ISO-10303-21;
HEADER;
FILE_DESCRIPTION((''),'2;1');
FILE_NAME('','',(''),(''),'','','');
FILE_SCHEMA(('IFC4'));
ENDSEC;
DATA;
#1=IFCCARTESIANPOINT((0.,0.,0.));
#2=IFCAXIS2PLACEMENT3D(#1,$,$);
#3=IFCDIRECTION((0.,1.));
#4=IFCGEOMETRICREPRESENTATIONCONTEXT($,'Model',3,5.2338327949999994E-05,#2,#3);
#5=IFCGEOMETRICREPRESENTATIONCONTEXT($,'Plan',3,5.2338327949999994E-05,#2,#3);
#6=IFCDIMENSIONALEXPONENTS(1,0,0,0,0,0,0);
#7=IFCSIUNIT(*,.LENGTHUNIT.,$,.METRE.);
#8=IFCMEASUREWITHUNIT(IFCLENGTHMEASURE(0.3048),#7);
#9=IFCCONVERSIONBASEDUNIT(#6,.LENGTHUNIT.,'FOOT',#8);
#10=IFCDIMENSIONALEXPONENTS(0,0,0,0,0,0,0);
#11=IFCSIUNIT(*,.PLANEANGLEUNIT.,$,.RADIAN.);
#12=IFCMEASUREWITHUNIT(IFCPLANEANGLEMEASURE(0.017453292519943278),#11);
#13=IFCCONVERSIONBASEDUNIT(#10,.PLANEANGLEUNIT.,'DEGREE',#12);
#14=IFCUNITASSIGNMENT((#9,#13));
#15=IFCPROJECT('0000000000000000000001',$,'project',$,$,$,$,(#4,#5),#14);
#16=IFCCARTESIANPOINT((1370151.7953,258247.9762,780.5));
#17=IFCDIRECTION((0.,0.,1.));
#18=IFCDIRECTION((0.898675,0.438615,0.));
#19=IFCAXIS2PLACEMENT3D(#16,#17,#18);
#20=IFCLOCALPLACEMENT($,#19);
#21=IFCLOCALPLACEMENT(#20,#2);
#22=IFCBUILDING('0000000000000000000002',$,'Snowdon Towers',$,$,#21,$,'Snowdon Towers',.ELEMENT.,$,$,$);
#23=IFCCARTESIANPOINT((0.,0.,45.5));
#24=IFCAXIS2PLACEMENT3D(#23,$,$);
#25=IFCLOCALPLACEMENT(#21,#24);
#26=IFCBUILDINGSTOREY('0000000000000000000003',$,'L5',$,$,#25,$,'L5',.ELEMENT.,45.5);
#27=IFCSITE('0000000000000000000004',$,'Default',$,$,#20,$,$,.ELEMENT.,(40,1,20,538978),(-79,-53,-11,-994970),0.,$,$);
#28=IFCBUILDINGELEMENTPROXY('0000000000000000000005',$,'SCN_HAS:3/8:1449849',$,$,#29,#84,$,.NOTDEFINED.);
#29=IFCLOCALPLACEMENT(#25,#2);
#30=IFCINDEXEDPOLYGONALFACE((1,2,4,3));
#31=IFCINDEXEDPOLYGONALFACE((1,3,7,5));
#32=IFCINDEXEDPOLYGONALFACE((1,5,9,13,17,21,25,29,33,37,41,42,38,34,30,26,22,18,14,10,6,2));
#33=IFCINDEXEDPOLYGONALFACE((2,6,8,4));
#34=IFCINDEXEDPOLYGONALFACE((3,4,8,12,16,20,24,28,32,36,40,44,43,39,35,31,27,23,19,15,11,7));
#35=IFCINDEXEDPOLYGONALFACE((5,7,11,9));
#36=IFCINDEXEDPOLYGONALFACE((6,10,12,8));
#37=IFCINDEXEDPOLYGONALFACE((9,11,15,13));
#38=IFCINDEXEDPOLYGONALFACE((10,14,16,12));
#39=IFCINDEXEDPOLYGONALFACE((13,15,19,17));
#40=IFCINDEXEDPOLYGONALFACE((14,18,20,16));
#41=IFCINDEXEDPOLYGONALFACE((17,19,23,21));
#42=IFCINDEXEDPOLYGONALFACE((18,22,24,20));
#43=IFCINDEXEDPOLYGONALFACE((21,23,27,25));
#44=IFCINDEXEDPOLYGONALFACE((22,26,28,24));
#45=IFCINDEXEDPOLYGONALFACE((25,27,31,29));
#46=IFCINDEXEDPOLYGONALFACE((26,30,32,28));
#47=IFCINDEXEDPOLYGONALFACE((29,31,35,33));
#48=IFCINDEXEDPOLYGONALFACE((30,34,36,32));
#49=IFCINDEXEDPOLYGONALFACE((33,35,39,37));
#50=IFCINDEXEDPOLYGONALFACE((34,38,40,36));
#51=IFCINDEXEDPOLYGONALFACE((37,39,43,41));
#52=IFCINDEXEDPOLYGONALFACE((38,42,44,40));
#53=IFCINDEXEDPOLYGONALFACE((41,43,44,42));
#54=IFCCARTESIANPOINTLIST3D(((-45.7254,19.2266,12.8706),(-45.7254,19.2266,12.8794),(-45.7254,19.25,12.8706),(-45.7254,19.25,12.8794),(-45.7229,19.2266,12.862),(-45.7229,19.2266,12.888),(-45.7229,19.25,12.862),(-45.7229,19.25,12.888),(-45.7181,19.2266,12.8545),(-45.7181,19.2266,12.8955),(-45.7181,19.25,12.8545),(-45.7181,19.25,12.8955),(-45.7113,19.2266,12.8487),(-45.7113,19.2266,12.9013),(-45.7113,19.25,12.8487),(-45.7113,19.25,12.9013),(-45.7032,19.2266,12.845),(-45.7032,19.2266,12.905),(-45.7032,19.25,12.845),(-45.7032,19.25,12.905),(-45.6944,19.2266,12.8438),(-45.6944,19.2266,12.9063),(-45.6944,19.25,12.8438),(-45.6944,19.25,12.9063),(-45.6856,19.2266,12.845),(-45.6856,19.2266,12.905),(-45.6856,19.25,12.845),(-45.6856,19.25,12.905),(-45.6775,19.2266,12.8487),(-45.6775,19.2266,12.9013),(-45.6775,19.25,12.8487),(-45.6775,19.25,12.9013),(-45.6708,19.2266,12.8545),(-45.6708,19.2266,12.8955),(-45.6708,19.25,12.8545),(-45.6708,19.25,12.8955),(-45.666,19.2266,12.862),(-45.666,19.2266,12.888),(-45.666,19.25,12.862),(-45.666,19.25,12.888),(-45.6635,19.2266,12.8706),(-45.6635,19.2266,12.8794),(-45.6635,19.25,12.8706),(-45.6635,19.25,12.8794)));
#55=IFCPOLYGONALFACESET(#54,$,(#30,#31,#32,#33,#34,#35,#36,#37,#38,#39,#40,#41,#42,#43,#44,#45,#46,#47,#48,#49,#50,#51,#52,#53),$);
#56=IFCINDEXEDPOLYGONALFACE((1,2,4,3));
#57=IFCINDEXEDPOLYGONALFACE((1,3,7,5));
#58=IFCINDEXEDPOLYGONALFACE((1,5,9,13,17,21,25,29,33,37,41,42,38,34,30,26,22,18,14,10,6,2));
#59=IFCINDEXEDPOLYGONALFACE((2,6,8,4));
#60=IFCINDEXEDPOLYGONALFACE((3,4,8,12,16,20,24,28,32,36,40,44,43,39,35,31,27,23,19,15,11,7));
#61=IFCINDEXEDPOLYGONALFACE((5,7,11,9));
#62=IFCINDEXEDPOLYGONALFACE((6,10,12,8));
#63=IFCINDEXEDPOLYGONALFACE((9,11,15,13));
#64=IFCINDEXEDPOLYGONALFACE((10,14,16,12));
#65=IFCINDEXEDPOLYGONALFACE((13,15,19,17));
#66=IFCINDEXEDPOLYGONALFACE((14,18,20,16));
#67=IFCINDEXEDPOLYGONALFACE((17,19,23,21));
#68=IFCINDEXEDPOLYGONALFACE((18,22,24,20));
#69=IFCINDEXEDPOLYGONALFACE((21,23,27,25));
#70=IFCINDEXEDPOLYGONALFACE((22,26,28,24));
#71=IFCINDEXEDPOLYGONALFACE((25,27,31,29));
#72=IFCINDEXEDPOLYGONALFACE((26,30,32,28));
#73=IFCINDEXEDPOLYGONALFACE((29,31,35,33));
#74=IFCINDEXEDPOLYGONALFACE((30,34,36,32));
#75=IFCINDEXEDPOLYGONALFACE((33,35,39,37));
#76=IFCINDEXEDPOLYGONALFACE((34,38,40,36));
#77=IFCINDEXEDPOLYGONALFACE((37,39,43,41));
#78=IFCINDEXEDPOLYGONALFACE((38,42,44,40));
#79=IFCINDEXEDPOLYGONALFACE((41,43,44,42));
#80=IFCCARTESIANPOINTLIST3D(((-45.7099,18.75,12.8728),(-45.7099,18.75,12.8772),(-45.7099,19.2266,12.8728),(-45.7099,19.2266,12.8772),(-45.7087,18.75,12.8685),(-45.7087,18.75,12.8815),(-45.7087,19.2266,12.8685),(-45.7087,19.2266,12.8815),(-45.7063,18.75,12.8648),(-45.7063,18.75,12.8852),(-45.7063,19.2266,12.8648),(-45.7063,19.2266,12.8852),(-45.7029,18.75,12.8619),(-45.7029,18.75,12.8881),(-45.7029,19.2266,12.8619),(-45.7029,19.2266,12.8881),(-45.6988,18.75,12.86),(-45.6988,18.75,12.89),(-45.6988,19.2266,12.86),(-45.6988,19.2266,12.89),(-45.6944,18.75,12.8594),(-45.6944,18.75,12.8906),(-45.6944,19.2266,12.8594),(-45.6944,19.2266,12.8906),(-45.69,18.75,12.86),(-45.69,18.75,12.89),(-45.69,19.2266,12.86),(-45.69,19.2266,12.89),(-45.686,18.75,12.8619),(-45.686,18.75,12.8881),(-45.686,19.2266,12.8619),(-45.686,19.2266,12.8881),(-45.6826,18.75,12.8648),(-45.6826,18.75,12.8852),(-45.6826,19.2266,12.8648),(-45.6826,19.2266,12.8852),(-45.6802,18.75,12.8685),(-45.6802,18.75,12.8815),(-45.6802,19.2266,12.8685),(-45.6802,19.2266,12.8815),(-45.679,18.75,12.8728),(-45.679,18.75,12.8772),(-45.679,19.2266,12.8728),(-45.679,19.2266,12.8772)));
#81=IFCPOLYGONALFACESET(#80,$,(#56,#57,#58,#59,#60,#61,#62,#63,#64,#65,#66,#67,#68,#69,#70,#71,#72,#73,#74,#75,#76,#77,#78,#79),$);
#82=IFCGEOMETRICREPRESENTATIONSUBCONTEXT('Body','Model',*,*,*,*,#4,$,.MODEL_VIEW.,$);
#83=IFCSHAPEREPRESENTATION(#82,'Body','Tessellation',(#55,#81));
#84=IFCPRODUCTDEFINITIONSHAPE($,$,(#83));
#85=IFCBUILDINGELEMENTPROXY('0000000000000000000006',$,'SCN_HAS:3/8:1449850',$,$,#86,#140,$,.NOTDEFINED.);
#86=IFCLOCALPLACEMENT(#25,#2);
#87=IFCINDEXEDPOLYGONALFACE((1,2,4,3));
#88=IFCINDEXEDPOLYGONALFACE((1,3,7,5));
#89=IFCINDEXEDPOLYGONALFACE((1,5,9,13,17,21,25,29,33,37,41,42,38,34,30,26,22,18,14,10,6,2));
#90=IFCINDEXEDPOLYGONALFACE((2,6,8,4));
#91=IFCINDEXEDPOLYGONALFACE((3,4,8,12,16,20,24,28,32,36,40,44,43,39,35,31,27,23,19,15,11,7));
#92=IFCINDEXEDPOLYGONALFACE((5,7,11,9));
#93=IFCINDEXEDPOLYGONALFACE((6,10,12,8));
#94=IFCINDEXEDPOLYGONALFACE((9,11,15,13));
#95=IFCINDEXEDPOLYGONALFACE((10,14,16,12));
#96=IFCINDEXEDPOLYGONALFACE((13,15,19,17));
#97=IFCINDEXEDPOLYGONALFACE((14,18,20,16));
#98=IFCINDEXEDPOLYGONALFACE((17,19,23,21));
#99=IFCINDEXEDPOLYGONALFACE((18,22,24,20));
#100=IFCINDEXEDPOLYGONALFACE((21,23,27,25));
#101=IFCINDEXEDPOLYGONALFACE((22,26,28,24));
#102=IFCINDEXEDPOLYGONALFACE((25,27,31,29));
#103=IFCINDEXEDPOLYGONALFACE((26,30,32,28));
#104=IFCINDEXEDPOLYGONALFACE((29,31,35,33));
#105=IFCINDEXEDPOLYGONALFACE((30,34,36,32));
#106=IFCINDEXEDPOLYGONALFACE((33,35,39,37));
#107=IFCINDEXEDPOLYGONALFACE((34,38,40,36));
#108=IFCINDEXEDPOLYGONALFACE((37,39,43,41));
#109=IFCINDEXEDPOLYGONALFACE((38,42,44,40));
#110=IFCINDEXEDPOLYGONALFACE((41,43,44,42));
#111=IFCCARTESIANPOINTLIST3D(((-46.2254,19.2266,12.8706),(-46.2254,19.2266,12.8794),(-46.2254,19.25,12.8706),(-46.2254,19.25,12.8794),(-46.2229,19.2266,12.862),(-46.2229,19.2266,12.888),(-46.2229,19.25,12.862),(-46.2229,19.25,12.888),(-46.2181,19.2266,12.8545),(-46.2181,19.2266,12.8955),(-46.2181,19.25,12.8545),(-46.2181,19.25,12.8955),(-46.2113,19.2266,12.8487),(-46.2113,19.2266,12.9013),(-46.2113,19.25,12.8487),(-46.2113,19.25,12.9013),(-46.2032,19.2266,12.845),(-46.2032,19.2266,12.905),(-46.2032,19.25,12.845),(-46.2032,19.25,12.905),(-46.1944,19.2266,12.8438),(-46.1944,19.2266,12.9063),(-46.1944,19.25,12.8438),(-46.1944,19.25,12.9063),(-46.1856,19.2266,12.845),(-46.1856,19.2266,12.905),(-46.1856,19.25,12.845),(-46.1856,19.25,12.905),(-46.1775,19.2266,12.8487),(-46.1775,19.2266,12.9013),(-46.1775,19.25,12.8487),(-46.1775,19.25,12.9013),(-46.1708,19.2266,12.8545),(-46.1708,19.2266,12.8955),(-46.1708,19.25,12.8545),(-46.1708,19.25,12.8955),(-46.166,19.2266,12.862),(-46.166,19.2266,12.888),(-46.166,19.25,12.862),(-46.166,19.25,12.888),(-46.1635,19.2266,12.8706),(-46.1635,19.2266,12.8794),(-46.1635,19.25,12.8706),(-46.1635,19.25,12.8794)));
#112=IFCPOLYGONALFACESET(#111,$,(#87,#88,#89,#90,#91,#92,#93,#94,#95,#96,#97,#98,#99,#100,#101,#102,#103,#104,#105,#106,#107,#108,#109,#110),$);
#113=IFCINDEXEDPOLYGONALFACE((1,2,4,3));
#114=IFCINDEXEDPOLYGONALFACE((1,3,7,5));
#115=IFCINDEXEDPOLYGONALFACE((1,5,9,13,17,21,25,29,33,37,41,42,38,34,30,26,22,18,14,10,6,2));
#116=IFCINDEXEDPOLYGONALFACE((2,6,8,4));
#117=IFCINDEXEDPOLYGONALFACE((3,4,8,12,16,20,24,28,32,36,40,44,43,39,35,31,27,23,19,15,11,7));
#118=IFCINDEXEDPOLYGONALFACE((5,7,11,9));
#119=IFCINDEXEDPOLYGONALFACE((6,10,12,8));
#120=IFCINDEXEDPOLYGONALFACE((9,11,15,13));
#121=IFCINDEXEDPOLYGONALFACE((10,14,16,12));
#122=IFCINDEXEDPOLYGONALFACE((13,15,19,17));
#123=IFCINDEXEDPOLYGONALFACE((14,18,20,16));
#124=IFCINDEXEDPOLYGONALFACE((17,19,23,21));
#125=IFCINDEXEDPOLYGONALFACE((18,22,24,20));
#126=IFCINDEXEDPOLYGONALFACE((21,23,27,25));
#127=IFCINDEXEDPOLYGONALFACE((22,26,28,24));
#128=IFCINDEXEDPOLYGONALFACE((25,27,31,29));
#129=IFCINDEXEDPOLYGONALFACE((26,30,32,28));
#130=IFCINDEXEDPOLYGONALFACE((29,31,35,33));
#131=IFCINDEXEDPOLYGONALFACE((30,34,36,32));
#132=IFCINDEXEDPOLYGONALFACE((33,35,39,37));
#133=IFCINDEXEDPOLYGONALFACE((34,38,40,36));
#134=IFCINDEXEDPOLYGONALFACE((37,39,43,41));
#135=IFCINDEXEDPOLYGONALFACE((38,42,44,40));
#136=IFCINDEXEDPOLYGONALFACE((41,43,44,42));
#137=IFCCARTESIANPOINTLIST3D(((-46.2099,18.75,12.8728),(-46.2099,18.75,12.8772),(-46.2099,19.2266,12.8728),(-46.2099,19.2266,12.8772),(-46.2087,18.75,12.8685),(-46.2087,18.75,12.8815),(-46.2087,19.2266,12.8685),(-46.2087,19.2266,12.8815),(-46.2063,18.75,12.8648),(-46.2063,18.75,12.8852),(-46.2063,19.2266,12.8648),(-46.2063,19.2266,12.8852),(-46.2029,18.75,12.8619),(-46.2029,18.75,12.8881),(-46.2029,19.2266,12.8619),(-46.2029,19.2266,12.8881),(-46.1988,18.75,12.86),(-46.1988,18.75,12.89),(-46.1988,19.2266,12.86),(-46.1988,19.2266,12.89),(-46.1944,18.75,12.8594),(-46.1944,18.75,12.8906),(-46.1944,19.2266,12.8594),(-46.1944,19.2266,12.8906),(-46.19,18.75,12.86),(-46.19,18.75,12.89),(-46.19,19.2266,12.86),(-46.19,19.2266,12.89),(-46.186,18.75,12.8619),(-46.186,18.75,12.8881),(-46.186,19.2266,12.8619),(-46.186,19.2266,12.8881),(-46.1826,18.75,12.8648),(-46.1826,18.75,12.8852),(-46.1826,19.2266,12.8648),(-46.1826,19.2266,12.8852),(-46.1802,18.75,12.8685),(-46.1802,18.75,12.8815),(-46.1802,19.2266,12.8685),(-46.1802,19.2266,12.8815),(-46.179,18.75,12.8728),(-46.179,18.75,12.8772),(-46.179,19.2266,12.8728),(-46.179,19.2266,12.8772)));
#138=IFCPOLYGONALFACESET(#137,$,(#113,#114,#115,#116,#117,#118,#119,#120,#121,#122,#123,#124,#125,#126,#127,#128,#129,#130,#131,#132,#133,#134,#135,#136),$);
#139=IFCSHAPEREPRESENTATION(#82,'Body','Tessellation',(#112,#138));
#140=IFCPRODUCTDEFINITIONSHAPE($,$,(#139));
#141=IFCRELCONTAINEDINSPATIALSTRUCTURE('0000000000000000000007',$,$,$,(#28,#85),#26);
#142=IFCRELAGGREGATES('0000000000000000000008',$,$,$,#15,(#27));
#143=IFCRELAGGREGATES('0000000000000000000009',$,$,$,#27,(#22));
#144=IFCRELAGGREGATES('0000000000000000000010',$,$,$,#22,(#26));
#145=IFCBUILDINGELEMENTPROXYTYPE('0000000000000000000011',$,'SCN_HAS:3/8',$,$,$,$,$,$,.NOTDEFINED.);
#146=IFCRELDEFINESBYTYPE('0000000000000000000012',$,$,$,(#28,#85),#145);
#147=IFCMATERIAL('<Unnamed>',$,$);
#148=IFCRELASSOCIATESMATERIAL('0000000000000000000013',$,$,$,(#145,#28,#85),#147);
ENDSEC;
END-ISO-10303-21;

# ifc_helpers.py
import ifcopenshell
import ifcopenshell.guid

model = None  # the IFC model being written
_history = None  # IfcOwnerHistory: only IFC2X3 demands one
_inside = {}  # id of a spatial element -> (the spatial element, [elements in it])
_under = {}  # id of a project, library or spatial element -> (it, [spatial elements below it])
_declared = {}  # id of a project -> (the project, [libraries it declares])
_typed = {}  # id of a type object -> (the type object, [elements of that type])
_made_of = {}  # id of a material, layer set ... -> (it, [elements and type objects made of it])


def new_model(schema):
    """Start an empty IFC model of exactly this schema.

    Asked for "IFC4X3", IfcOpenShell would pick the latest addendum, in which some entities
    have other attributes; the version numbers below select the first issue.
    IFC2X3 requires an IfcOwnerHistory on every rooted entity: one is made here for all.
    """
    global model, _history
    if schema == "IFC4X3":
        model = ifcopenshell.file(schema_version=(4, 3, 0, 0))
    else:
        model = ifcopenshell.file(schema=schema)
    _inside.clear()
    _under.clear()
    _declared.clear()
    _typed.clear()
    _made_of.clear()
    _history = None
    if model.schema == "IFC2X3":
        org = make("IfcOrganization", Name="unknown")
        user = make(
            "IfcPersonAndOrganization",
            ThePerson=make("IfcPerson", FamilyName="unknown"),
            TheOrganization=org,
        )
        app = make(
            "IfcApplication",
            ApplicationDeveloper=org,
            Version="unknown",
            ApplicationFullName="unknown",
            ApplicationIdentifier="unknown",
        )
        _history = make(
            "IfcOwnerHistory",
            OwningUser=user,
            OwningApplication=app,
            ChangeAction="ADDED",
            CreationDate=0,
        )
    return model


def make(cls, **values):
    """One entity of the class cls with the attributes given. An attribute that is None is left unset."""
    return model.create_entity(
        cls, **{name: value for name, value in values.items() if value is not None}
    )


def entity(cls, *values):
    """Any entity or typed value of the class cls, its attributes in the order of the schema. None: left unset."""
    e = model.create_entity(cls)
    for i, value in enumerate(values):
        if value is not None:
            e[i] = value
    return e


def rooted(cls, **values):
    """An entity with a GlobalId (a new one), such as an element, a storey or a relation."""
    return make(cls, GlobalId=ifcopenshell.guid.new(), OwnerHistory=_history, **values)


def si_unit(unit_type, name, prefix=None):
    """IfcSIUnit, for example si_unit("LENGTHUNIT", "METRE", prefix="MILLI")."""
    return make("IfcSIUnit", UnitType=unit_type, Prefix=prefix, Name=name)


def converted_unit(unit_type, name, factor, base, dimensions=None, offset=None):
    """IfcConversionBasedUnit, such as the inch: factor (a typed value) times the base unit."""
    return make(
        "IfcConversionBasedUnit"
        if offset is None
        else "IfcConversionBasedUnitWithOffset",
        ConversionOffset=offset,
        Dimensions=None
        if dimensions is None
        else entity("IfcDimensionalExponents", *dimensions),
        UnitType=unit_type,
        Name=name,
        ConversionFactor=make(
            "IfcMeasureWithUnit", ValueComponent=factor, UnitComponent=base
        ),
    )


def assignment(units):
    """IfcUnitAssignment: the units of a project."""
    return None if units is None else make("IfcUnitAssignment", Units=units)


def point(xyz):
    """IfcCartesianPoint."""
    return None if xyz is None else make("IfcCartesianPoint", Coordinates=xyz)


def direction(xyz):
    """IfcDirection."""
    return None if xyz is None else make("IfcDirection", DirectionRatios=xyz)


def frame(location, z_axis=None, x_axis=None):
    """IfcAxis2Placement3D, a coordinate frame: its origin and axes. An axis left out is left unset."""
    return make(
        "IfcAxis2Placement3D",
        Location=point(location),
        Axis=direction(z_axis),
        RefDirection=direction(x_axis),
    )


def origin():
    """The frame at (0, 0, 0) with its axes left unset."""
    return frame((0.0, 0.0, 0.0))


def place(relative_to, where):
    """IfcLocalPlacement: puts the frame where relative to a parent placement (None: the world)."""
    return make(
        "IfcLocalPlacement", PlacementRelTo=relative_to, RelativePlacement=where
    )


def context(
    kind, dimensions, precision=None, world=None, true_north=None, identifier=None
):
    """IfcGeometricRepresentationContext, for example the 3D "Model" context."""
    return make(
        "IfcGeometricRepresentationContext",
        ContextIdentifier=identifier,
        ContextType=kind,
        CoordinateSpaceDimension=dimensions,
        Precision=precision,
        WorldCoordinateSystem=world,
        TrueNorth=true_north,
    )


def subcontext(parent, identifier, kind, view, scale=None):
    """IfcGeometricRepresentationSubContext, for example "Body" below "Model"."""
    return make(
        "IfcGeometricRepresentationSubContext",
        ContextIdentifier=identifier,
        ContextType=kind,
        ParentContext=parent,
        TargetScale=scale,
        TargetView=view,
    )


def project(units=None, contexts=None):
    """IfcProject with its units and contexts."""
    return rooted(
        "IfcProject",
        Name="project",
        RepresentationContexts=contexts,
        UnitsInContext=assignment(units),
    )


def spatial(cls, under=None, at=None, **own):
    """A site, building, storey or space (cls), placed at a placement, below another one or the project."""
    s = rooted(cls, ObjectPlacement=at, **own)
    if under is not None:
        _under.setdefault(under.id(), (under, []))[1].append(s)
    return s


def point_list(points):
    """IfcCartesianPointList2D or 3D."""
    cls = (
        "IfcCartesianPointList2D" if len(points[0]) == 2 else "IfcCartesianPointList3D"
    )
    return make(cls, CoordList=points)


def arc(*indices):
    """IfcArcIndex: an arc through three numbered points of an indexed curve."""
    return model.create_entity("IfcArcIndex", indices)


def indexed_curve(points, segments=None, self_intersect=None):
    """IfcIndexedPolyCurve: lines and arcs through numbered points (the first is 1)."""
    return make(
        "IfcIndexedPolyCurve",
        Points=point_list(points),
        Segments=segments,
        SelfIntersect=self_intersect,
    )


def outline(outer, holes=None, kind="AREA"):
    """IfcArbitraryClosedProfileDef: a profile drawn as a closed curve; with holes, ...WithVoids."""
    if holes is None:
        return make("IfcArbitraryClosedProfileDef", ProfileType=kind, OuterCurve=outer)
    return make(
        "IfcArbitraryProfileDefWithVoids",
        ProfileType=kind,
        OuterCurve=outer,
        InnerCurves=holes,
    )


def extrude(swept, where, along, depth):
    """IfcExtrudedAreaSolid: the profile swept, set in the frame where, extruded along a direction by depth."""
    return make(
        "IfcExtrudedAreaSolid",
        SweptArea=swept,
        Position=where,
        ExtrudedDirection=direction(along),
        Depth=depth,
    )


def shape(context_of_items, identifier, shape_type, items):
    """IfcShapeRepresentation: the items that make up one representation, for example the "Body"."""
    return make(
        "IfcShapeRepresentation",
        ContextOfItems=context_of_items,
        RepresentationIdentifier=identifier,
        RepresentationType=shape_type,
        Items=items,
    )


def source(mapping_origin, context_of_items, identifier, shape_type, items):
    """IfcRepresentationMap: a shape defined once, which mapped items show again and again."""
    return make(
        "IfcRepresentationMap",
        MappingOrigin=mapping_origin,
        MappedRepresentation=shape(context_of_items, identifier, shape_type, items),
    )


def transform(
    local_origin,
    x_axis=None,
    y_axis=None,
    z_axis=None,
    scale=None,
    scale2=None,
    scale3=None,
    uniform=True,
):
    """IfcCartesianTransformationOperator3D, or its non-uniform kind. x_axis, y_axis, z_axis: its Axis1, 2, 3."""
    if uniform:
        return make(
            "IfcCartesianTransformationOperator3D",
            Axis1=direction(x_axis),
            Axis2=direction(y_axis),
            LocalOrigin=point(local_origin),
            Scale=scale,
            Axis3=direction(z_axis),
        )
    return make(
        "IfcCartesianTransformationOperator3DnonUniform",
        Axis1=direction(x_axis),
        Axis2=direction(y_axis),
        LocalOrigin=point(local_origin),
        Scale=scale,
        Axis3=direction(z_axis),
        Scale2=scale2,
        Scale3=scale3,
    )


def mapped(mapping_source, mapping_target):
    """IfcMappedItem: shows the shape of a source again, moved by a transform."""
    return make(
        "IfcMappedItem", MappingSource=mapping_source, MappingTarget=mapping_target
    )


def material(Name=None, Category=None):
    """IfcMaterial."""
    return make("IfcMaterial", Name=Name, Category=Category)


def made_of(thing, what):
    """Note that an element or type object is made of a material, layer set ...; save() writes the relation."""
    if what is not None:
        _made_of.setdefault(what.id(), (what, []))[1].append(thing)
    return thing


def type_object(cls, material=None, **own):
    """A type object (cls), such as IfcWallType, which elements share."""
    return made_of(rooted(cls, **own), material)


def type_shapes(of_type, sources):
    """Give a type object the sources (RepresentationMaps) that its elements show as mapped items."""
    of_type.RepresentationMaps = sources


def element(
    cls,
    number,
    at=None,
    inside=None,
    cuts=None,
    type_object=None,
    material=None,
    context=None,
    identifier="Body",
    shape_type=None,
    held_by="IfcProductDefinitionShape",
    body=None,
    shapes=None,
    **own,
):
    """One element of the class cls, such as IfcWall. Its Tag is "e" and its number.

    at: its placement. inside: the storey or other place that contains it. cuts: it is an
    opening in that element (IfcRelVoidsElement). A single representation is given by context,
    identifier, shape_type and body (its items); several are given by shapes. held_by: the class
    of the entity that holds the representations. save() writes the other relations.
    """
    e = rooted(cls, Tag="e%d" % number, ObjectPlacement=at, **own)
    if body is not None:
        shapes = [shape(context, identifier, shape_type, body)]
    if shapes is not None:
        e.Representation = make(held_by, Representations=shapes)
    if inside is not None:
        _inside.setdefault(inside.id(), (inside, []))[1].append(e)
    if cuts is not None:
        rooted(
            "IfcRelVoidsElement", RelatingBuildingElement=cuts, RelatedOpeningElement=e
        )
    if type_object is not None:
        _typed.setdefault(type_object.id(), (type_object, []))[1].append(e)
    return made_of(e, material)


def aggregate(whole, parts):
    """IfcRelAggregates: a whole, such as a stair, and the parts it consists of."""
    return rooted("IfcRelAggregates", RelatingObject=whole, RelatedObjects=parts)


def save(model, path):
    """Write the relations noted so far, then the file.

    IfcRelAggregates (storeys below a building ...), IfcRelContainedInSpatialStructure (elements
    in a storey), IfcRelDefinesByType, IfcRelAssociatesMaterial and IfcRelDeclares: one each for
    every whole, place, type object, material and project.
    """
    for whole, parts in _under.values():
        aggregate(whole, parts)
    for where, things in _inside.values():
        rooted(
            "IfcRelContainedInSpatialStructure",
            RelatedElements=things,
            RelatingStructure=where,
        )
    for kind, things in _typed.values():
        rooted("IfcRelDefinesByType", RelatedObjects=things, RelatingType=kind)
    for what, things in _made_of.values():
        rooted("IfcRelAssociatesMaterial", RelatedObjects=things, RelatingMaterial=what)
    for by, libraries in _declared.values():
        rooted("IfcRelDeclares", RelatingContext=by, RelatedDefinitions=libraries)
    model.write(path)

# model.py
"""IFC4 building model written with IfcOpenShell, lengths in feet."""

from ifc_helpers import new_model, entity, si_unit, converted_unit, direction, frame, origin, place, context, subcontext, project, spatial, arc, indexed_curve, outline, extrude, source, transform, mapped, material, type_object, type_shapes, element, save


model = new_model("IFC4")

# Units and contexts
model_context = context("Model", 3, precision=5.2338327949999994e-05, world=origin(), true_north=direction((0.0, 1.0)))
plan_context = context("Plan", 3, precision=5.2338327949999994e-05, world=origin(), true_north=direction((0.0, 1.0)))
body_context = subcontext(model_context, "Body", "Model", "MODEL_VIEW")
ifc_project = project(units=[converted_unit("LENGTHUNIT", "FOOT", entity("IfcLengthMeasure", 0.3048), si_unit("LENGTHUNIT", "METRE"), dimensions=[1, 0, 0, 0, 0, 0, 0]), converted_unit("PLANEANGLEUNIT", "DEGREE", entity("IfcPlaneAngleMeasure", 0.017453292519943278), si_unit("PLANEANGLEUNIT", "RADIAN"), dimensions=[0, 0, 0, 0, 0, 0, 0])], contexts=[model_context, plan_context])

# Site, building, storey
site_placement = place(None, frame((1370151.7953, 258247.9762, 780.5), z_axis=(0.0, 0.0, 1.0), x_axis=(0.898675, 0.438615, 0.0)))
site = spatial("IfcSite", under=ifc_project, at=site_placement, Name="Default", CompositionType="ELEMENT", RefLatitude=(40, 1, 20, 538978), RefLongitude=(-79, -53, -11, -994970), RefElevation=0.0)
building_placement = place(site_placement, origin())
building = spatial("IfcBuilding", under=site, at=building_placement, Name="Snowdon Towers", LongName="Snowdon Towers", CompositionType="ELEMENT")
storey_placement = place(building_placement, frame((0.0, 0.0, 45.5)))
storey = spatial("IfcBuildingStorey", under=building, at=storey_placement, Name="L5", LongName="L5", CompositionType="ELEMENT", Elevation=45.5)

# Building element proxies
ifc_material_1 = material(Name="<Unnamed>")
building_element_proxy_type_1 = type_object("IfcBuildingElementProxyType", Name="SCN_HAS:3/8", PredefinedType="NOTDEFINED", material=ifc_material_1)
shared_shape_1 = source(origin(), body_context, "Body", "SweptSolid", [
    extrude(outline(indexed_curve([(-0.0312, 0.0), (0.0, -0.0313), (0.0312, 0.0), (0.0, 0.0312)], segments=[arc(1, 2, 3), arc(3, 4, 1)], self_intersect=False)), frame((0.0, 0.0, -0.5), z_axis=(0.0, 0.0, 1.0), x_axis=(0.0, -1.0, 0.0)), (0.0, 0.0, 1.0), 0.0234),
    extrude(outline(indexed_curve([(-0.0156, 0.0), (0.0, -0.0156), (0.0156, 0.0), (0.0, 0.0156)], segments=[arc(1, 2, 3), arc(3, 4, 1)], self_intersect=False)), frame((0.0, 0.0, -0.4766), z_axis=(0.0, 0.0, 1.0), x_axis=(0.0, -1.0, 0.0)), (0.0, 0.0, 1.0), 0.4766),
])
type_shapes(building_element_proxy_type_1, [shared_shape_1])
for number, where, z_axis, x_axis, name in (
    (1, (-45.6944, 18.75, 12.875), (0.0, -1.0, 0.0), (1.0, 0.0, 0.0), "SCN_HAS:3/8:1449849"),
    (2, (-46.1944, 18.75, 12.875), (0.0, -1.0, 0.0), (1.0, 0.0, 0.0), "SCN_HAS:3/8:1449850"),
):
    element("IfcBuildingElementProxy", number, at=place(storey_placement, frame(where, z_axis=z_axis, x_axis=x_axis)), inside=storey, type_object=building_element_proxy_type_1, material=ifc_material_1, Name=name, PredefinedType="NOTDEFINED", context=body_context, shape_type="MappedRepresentation", body=[
        mapped(shared_shape_1, transform((0.0, 0.0, 0.0), scale=1.0)),
    ])

save(model, "model.ifc")
